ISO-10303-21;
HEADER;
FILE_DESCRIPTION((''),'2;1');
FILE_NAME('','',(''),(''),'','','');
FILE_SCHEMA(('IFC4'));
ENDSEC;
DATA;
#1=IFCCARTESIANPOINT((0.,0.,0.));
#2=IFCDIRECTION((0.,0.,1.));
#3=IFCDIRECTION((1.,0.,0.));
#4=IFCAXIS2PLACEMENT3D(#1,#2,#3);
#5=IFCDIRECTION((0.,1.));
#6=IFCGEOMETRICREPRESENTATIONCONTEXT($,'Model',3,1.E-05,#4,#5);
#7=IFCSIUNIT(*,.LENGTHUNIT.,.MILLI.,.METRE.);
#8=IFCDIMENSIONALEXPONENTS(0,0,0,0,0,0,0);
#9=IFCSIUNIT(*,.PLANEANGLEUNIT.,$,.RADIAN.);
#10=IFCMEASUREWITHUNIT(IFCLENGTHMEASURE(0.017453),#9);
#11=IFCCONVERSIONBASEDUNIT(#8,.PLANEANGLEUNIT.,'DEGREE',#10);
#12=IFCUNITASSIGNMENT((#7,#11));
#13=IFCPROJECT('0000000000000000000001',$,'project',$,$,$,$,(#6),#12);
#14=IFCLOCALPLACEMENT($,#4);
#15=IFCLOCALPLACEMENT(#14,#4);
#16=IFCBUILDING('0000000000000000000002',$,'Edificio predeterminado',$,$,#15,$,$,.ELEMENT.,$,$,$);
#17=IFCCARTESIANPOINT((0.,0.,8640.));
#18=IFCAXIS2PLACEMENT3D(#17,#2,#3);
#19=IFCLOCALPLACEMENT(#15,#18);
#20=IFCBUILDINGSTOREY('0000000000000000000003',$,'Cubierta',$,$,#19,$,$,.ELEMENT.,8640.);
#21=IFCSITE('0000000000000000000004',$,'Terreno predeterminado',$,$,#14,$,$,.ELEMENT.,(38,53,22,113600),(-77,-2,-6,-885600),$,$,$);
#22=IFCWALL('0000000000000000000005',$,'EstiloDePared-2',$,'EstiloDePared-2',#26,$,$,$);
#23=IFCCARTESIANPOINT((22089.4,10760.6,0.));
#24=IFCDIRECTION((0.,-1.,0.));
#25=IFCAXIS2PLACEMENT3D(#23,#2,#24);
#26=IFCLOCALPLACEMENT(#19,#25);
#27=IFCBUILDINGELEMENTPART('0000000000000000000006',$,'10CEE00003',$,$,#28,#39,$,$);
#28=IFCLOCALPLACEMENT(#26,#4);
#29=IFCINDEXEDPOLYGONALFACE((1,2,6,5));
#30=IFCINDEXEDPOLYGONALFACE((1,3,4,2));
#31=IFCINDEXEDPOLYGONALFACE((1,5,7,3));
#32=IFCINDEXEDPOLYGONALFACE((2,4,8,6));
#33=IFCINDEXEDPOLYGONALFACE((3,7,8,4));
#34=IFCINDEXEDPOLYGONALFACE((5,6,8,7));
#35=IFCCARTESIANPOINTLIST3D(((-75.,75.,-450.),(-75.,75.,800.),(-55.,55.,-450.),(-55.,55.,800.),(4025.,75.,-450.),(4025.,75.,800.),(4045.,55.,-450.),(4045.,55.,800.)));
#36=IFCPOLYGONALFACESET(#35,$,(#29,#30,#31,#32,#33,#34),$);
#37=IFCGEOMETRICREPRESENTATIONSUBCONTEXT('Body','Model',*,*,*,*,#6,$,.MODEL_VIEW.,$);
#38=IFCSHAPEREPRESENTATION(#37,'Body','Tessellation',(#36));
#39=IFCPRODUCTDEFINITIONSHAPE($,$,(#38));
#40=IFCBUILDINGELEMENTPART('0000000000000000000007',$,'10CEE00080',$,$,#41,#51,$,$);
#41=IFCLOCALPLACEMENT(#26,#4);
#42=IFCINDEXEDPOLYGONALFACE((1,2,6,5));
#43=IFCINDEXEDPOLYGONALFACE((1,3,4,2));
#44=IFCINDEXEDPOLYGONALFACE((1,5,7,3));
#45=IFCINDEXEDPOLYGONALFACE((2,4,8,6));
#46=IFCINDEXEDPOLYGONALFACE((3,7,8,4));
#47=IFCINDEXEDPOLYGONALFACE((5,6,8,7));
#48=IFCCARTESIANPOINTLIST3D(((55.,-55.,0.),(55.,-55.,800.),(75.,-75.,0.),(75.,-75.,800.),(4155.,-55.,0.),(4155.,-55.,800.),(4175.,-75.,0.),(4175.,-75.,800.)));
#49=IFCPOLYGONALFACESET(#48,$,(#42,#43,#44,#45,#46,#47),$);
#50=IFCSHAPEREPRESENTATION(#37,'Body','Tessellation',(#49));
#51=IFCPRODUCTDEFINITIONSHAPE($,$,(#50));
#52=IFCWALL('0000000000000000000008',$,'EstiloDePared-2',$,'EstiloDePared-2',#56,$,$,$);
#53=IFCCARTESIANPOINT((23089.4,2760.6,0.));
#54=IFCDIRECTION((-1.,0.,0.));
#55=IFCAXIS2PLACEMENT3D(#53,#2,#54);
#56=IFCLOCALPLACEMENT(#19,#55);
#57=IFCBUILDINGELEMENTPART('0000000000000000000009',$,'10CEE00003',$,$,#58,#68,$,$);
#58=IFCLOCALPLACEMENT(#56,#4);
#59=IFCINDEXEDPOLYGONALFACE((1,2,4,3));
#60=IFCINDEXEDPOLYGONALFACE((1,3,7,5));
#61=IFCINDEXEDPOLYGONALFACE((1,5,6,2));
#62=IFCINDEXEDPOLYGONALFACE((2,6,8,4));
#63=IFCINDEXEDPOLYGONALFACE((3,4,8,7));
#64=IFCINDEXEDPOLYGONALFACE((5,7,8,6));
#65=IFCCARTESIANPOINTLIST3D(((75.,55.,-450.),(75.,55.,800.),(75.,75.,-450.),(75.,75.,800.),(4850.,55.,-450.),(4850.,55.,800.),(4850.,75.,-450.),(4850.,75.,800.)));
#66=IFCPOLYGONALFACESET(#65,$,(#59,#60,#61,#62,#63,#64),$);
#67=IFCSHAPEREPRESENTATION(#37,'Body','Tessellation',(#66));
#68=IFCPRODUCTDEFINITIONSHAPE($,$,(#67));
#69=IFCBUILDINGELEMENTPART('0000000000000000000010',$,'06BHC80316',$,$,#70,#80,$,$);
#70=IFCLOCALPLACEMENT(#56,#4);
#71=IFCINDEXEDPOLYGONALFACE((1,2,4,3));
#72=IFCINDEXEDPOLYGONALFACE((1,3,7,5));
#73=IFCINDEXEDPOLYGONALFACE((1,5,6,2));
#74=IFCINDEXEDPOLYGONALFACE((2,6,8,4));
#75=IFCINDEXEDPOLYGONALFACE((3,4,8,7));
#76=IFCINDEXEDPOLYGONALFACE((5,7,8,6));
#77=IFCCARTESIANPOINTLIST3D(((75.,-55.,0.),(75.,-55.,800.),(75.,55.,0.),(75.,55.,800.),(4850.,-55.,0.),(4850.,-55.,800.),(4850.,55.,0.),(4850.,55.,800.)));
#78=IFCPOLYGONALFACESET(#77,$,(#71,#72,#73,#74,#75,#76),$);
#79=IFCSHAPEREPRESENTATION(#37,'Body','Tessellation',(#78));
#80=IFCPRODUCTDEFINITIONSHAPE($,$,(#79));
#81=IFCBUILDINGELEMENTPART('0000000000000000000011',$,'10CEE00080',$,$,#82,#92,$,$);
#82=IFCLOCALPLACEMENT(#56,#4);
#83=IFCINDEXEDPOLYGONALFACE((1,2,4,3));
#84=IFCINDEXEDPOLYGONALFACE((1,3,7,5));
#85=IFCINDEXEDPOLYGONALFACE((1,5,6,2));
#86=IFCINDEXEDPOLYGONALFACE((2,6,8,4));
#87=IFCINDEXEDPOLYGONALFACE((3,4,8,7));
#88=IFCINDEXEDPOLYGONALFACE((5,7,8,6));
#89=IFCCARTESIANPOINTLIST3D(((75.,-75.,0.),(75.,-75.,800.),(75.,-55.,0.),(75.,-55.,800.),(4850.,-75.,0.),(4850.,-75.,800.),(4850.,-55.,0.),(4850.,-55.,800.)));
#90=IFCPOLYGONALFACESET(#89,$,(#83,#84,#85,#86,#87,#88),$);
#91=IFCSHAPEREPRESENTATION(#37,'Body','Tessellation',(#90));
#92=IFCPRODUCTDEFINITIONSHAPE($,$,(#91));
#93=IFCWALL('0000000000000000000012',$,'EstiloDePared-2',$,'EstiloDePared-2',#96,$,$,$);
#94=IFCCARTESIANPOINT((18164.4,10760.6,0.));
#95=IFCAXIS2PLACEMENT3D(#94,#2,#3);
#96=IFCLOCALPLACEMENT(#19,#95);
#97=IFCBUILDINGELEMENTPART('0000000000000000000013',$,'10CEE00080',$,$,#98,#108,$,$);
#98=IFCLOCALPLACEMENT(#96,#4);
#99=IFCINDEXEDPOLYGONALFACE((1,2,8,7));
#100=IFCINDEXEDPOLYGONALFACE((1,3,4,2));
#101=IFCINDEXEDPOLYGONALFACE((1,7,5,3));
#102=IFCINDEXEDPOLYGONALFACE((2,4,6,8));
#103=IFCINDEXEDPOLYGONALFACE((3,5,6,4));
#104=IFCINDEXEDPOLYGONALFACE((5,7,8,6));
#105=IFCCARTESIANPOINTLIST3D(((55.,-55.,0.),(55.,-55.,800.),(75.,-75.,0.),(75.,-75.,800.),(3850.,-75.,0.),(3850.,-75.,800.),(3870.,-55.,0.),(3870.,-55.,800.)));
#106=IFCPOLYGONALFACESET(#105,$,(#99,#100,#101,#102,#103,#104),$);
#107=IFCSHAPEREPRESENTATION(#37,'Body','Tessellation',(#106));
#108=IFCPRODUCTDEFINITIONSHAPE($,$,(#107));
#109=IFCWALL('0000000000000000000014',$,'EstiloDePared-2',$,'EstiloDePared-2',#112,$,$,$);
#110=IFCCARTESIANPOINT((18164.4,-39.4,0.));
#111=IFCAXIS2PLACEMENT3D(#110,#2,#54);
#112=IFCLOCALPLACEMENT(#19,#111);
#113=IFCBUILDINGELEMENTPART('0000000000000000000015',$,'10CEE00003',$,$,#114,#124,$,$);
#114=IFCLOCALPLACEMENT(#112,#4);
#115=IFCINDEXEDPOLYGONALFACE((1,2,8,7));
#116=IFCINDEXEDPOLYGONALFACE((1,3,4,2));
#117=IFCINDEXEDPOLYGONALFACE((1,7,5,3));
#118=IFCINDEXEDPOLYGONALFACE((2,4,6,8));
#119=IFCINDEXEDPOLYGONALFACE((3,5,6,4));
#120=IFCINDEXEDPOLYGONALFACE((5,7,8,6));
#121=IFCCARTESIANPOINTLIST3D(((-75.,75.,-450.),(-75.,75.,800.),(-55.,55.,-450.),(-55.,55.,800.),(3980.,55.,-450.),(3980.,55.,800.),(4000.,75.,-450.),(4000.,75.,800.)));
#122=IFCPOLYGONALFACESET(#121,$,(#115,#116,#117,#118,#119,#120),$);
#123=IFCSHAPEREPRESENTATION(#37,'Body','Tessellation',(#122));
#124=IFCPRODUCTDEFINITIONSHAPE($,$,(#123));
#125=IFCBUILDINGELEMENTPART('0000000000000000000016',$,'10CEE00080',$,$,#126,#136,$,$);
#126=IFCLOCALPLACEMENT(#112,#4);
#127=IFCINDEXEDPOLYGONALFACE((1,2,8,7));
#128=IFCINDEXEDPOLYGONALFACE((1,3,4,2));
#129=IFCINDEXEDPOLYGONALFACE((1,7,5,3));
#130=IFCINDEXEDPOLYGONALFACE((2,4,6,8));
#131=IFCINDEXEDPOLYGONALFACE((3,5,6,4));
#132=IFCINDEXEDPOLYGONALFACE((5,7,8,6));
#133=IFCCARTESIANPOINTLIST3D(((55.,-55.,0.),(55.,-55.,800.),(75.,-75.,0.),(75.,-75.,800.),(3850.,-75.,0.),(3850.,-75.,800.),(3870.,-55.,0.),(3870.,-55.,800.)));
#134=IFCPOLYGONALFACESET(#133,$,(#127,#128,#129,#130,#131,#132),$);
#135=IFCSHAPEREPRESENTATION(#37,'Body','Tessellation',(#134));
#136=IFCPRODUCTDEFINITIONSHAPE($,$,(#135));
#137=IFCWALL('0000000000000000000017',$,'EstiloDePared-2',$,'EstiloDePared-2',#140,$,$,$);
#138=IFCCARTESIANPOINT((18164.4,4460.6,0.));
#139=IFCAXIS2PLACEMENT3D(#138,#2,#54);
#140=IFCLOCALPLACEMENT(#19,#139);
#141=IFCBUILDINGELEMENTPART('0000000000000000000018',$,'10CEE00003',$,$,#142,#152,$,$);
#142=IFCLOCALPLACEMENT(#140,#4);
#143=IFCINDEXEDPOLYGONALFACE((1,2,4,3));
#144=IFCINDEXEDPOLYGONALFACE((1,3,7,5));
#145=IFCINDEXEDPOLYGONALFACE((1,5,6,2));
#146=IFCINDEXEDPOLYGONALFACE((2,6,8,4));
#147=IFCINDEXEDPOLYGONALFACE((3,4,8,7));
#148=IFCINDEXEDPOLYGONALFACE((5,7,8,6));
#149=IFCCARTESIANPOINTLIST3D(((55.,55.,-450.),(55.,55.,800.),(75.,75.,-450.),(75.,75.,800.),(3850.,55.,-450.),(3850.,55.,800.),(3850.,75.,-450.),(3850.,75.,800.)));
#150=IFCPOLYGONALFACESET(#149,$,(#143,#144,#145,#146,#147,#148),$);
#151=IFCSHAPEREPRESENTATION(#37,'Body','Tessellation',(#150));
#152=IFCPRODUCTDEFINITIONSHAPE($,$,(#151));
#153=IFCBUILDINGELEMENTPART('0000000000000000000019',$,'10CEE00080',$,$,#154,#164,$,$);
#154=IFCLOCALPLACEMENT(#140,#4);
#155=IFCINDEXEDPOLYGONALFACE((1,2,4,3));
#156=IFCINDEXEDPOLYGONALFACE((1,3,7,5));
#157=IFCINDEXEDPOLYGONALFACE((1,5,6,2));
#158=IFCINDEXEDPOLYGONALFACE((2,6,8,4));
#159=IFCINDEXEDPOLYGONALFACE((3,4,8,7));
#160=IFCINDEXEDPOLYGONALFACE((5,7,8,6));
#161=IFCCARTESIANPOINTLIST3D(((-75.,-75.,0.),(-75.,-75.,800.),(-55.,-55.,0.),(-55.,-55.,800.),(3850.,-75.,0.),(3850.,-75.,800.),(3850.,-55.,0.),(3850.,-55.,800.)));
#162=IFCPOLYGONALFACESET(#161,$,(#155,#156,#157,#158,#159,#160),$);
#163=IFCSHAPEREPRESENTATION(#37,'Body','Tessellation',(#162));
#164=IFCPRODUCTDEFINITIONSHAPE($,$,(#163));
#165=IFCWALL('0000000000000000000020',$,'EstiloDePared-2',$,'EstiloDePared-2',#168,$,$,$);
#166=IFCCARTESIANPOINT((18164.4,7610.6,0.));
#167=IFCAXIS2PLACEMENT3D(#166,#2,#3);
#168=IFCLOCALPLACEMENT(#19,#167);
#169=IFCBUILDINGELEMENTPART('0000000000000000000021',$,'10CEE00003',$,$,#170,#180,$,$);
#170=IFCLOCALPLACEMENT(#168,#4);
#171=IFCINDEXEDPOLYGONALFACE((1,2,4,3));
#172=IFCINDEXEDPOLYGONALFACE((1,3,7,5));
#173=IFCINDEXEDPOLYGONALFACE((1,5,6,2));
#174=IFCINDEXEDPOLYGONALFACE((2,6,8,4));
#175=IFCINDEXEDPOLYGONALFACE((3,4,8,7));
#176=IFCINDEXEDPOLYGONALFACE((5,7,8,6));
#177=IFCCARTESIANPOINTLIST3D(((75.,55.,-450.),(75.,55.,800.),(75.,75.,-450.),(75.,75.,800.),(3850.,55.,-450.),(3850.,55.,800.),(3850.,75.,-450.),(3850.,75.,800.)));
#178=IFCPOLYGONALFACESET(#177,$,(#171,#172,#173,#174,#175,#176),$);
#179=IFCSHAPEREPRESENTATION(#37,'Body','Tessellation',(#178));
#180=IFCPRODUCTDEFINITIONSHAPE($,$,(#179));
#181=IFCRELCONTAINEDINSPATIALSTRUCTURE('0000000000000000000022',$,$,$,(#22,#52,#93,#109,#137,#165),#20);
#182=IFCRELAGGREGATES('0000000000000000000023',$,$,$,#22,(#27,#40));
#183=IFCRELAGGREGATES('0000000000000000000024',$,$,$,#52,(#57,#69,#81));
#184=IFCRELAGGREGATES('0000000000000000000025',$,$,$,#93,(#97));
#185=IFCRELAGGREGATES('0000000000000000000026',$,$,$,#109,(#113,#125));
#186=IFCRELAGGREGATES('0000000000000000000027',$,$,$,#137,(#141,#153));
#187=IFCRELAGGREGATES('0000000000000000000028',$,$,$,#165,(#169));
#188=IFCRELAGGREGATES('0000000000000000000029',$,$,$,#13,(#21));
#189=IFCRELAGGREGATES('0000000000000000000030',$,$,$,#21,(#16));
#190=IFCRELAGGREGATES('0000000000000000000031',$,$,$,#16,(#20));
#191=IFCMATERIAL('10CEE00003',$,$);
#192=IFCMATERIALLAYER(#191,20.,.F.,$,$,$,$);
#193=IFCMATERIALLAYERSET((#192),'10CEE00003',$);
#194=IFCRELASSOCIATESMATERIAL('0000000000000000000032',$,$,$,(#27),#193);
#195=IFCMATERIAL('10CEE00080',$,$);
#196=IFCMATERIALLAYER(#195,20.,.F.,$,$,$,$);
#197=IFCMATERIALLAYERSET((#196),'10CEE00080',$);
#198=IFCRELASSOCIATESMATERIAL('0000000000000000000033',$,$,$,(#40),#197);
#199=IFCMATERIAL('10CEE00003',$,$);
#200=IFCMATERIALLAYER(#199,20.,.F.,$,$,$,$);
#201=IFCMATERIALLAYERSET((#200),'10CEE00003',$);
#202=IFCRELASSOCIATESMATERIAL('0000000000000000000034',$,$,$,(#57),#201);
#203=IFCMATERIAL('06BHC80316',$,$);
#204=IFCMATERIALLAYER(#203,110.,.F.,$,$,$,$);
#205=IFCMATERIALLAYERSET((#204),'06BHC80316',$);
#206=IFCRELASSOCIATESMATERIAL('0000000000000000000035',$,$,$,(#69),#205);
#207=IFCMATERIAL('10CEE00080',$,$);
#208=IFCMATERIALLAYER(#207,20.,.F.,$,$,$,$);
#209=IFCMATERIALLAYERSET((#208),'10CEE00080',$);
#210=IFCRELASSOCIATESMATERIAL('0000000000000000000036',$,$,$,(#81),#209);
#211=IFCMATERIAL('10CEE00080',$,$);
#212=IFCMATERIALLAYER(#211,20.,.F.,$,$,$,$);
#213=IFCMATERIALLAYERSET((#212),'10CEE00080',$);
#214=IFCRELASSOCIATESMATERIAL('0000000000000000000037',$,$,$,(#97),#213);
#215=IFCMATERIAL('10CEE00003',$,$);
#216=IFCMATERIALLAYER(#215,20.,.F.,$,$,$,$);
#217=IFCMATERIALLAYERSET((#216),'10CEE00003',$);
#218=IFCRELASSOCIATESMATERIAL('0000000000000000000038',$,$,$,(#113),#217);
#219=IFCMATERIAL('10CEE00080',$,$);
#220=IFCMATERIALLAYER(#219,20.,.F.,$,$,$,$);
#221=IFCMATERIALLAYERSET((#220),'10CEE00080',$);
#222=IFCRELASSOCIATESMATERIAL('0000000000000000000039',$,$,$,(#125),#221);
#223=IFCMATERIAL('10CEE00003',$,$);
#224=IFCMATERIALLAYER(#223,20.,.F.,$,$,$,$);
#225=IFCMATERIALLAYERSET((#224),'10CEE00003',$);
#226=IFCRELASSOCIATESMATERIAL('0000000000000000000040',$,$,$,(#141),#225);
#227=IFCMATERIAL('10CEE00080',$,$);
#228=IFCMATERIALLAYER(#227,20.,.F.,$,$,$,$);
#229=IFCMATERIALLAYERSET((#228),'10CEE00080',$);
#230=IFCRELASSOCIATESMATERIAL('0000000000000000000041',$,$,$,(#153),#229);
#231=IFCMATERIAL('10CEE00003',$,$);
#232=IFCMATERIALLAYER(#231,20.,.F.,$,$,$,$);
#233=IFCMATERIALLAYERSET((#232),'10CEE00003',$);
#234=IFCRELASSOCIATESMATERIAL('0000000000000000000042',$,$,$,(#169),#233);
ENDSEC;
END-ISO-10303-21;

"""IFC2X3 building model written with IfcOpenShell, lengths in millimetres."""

from ifc_helpers import new_model, entity, si_unit, converted_unit, direction, frame, origin_with_axes, place, context, subcontext, project, spatial, polyline, outline, extrude, material, layer, layer_set, layer_usage, element, aggregate, save


model = new_model("IFC2X3")

# Units and contexts
model_context = context("Model", 3, precision=1e-05, world=origin_with_axes(), true_north=direction((0.0, 1.0)))
body_context = subcontext(model_context, "Body", "Model", "MODEL_VIEW")
ifc_project = project(units=[si_unit("LENGTHUNIT", "METRE", prefix="MILLI"), converted_unit("PLANEANGLEUNIT", "DEGREE", entity("IfcLengthMeasure", 0.017453), si_unit("PLANEANGLEUNIT", "RADIAN"), dimensions=[0, 0, 0, 0, 0, 0, 0])], contexts=[model_context])

# Site, building, storey
site_placement = place(None, origin_with_axes())
site = spatial("IfcSite", under=ifc_project, at=site_placement, Name="Terreno predeterminado", CompositionType="ELEMENT", RefLatitude=(38, 53, 22, 113600), RefLongitude=(-77, -2, -6, -885600))
building_placement = place(site_placement, origin_with_axes())
building = spatial("IfcBuilding", under=site, at=building_placement, Name="Edificio predeterminado", CompositionType="ELEMENT")
storey_placement = place(building_placement, frame((0.0, 0.0, 8640.0), z_axis=(0.0, 0.0, 1.0), x_axis=(1.0, 0.0, 0.0)))
storey = spatial("IfcBuildingStorey", under=building, at=storey_placement, Name="Cubierta", CompositionType="ELEMENT", Elevation=8640.0)

# Walls, building element parts
wall_1_placement = place(storey_placement, frame((22089.4, 10760.6, 0.0), z_axis=(0.0, 0.0, 1.0), x_axis=(0.0, -1.0, 0.0)))
wall_1 = element("IfcWall", 1, at=wall_1_placement, inside=storey, Name="EstiloDePared-2", ObjectType="EstiloDePared-2")
ifc_material_1 = material(Name="10CEE00003")
ifc_layer_1 = layer(ifc_material_1, 20.0, ventilated=False)
ifc_layer_set_1 = layer_set([ifc_layer_1], Name="10CEE00003")
ifc_layer_usage_1 = layer_usage(ifc_layer_set_1, "AXIS2", "NEGATIVE", -75.0)
building_element_part_1_placement = place(wall_1_placement, origin_with_axes())
building_element_part_1 = element("IfcBuildingElementPart", 2, at=building_element_part_1_placement, material=ifc_layer_usage_1, Name="10CEE00003", context=body_context, shape_type="SweptSolid", body=[
    extrude(outline(polyline([(4025.0, 75.0), (4045.0, 55.0), (-55.0, 55.0), (-75.0, 75.0), (4025.0, 75.0)])), frame((0.0, 0.0, -450.0), z_axis=(0.0, 0.0, 1.0), x_axis=(1.0, 0.0, 0.0)), (0.0, 0.0, 1.0), 1250.0),
])
ifc_material_2 = material(Name="10CEE00080")
ifc_layer_2 = layer(ifc_material_2, 20.0, ventilated=False)
ifc_layer_set_2 = layer_set([ifc_layer_2], Name="10CEE00080")
ifc_layer_usage_2 = layer_usage(ifc_layer_set_2, "AXIS2", "NEGATIVE", 55.0)
building_element_part_2_placement = place(wall_1_placement, origin_with_axes())
building_element_part_2 = element("IfcBuildingElementPart", 3, at=building_element_part_2_placement, material=ifc_layer_usage_2, Name="10CEE00080", context=body_context, shape_type="SweptSolid", body=[
    extrude(outline(polyline([(4155.0, -55.0), (4175.0, -75.0), (75.0, -75.0), (55.0, -55.0), (4155.0, -55.0)])), origin_with_axes(), (0.0, 0.0, 1.0), 800.0),
])
aggregate(wall_1, [building_element_part_1, building_element_part_2])
wall_2_placement = place(storey_placement, frame((23089.4, 2760.6, 0.0), z_axis=(0.0, 0.0, 1.0), x_axis=(-1.0, 0.0, 0.0)))
wall_2 = element("IfcWall", 4, at=wall_2_placement, inside=storey, Name="EstiloDePared-2", ObjectType="EstiloDePared-2")
ifc_material_3 = material(Name="10CEE00003")
ifc_layer_3 = layer(ifc_material_3, 20.0, ventilated=False)
ifc_layer_set_3 = layer_set([ifc_layer_3], Name="10CEE00003")
ifc_layer_usage_3 = layer_usage(ifc_layer_set_3, "AXIS2", "NEGATIVE", -75.0)
building_element_part_3_placement = place(wall_2_placement, origin_with_axes())
building_element_part_3 = element("IfcBuildingElementPart", 5, at=building_element_part_3_placement, material=ifc_layer_usage_3, Name="10CEE00003", context=body_context, shape_type="SweptSolid", body=[
    extrude(outline(polyline([(4850.0, 75.0), (4850.0, 55.0), (75.0, 55.0), (75.0, 75.0), (4850.0, 75.0)])), frame((0.0, 0.0, -450.0), z_axis=(0.0, 0.0, 1.0), x_axis=(1.0, 0.0, 0.0)), (0.0, 0.0, 1.0), 1250.0),
])
ifc_material_4 = material(Name="06BHC80316")
ifc_layer_4 = layer(ifc_material_4, 110.0, ventilated=False)
ifc_layer_set_4 = layer_set([ifc_layer_4], Name="06BHC80316")
ifc_layer_usage_4 = layer_usage(ifc_layer_set_4, "AXIS2", "NEGATIVE", -55.0)
building_element_part_4_placement = place(wall_2_placement, origin_with_axes())
building_element_part_4 = element("IfcBuildingElementPart", 6, at=building_element_part_4_placement, material=ifc_layer_usage_4, Name="06BHC80316", context=body_context, shape_type="SweptSolid", body=[
    extrude(outline(polyline([(4850.0, 55.0), (4850.0, -55.0), (75.0, -55.0), (75.0, 55.0), (4850.0, 55.0)])), origin_with_axes(), (0.0, 0.0, 1.0), 800.0),
])
ifc_material_5 = material(Name="10CEE00080")
ifc_layer_5 = layer(ifc_material_5, 20.0, ventilated=False)
ifc_layer_set_5 = layer_set([ifc_layer_5], Name="10CEE00080")
ifc_layer_usage_5 = layer_usage(ifc_layer_set_5, "AXIS2", "NEGATIVE", 55.0)
building_element_part_5_placement = place(wall_2_placement, origin_with_axes())
building_element_part_5 = element("IfcBuildingElementPart", 7, at=building_element_part_5_placement, material=ifc_layer_usage_5, Name="10CEE00080", context=body_context, shape_type="SweptSolid", body=[
    extrude(outline(polyline([(4850.0, -55.0), (4850.0, -75.0), (75.0, -75.0), (75.0, -55.0), (4850.0, -55.0)])), origin_with_axes(), (0.0, 0.0, 1.0), 800.0),
])
aggregate(wall_2, [building_element_part_3, building_element_part_4, building_element_part_5])

# Wall, building element part
wall_3_placement = place(storey_placement, frame((18164.4, 10760.6, 0.0), z_axis=(0.0, 0.0, 1.0), x_axis=(1.0, 0.0, 0.0)))
wall_3 = element("IfcWall", 8, at=wall_3_placement, inside=storey, Name="EstiloDePared-2", ObjectType="EstiloDePared-2")
ifc_material_6 = material(Name="10CEE00080")
ifc_layer_6 = layer(ifc_material_6, 20.0, ventilated=False)
ifc_layer_set_6 = layer_set([ifc_layer_6], Name="10CEE00080")
ifc_layer_usage_6 = layer_usage(ifc_layer_set_6, "AXIS2", "NEGATIVE", 55.0)
building_element_part_6_placement = place(wall_3_placement, origin_with_axes())
building_element_part_6 = element("IfcBuildingElementPart", 9, at=building_element_part_6_placement, material=ifc_layer_usage_6, Name="10CEE00080", context=body_context, shape_type="SweptSolid", body=[
    extrude(outline(polyline([(3870.0, -55.0), (3850.0, -75.0), (75.0, -75.0), (55.0, -55.0), (3870.0, -55.0)])), origin_with_axes(), (0.0, 0.0, 1.0), 800.0),
])
aggregate(wall_3, [building_element_part_6])

# Walls, building element parts
wall_4_placement = place(storey_placement, frame((18164.4, -39.4, 0.0), z_axis=(0.0, 0.0, 1.0), x_axis=(-1.0, 0.0, 0.0)))
wall_4 = element("IfcWall", 10, at=wall_4_placement, inside=storey, Name="EstiloDePared-2", ObjectType="EstiloDePared-2")
ifc_material_7 = material(Name="10CEE00003")
ifc_layer_7 = layer(ifc_material_7, 20.0, ventilated=False)
ifc_layer_set_7 = layer_set([ifc_layer_7], Name="10CEE00003")
ifc_layer_usage_7 = layer_usage(ifc_layer_set_7, "AXIS2", "NEGATIVE", -75.0)
building_element_part_7_placement = place(wall_4_placement, origin_with_axes())
building_element_part_7 = element("IfcBuildingElementPart", 11, at=building_element_part_7_placement, material=ifc_layer_usage_7, Name="10CEE00003", context=body_context, shape_type="SweptSolid", body=[
    extrude(outline(polyline([(4000.0, 75.0), (3980.0, 55.0), (-55.0, 55.0), (-75.0, 75.0), (4000.0, 75.0)])), frame((0.0, 0.0, -450.0), z_axis=(0.0, 0.0, 1.0), x_axis=(1.0, 0.0, 0.0)), (0.0, 0.0, 1.0), 1250.0),
])
ifc_material_8 = material(Name="10CEE00080")
ifc_layer_8 = layer(ifc_material_8, 20.0, ventilated=False)
ifc_layer_set_8 = layer_set([ifc_layer_8], Name="10CEE00080")
ifc_layer_usage_8 = layer_usage(ifc_layer_set_8, "AXIS2", "NEGATIVE", 55.0)
building_element_part_8_placement = place(wall_4_placement, origin_with_axes())
building_element_part_8 = element("IfcBuildingElementPart", 12, at=building_element_part_8_placement, material=ifc_layer_usage_8, Name="10CEE00080", context=body_context, shape_type="SweptSolid", body=[
    extrude(outline(polyline([(3870.0, -55.0), (3850.0, -75.0), (75.0, -75.0), (55.0, -55.0), (3870.0, -55.0)])), origin_with_axes(), (0.0, 0.0, 1.0), 800.0),
])
aggregate(wall_4, [building_element_part_7, building_element_part_8])
wall_5_placement = place(storey_placement, frame((18164.4, 4460.6, 0.0), z_axis=(0.0, 0.0, 1.0), x_axis=(-1.0, 0.0, 0.0)))
wall_5 = element("IfcWall", 13, at=wall_5_placement, inside=storey, Name="EstiloDePared-2", ObjectType="EstiloDePared-2")
ifc_material_9 = material(Name="10CEE00003")
ifc_layer_9 = layer(ifc_material_9, 20.0, ventilated=False)
ifc_layer_set_9 = layer_set([ifc_layer_9], Name="10CEE00003")
ifc_layer_usage_9 = layer_usage(ifc_layer_set_9, "AXIS2", "NEGATIVE", -75.0)
building_element_part_9_placement = place(wall_5_placement, origin_with_axes())
building_element_part_9 = element("IfcBuildingElementPart", 14, at=building_element_part_9_placement, material=ifc_layer_usage_9, Name="10CEE00003", context=body_context, shape_type="SweptSolid", body=[
    extrude(outline(polyline([(3850.0, 75.0), (3850.0, 55.0), (55.0, 55.0), (75.0, 75.0), (3850.0, 75.0)])), frame((0.0, 0.0, -450.0), z_axis=(0.0, 0.0, 1.0), x_axis=(1.0, 0.0, 0.0)), (0.0, 0.0, 1.0), 1250.0),
])
ifc_material_10 = material(Name="10CEE00080")
ifc_layer_10 = layer(ifc_material_10, 20.0, ventilated=False)
ifc_layer_set_10 = layer_set([ifc_layer_10], Name="10CEE00080")
ifc_layer_usage_10 = layer_usage(ifc_layer_set_10, "AXIS2", "NEGATIVE", 55.0)
building_element_part_10_placement = place(wall_5_placement, origin_with_axes())
building_element_part_10 = element("IfcBuildingElementPart", 15, at=building_element_part_10_placement, material=ifc_layer_usage_10, Name="10CEE00080", context=body_context, shape_type="SweptSolid", body=[
    extrude(outline(polyline([(3850.0, -55.0), (3850.0, -75.0), (-75.0, -75.0), (-55.0, -55.0), (3850.0, -55.0)])), origin_with_axes(), (0.0, 0.0, 1.0), 800.0),
])
aggregate(wall_5, [building_element_part_9, building_element_part_10])
wall_6_placement = place(storey_placement, frame((18164.4, 7610.6, 0.0), z_axis=(0.0, 0.0, 1.0), x_axis=(1.0, 0.0, 0.0)))
wall_6 = element("IfcWall", 16, at=wall_6_placement, inside=storey, Name="EstiloDePared-2", ObjectType="EstiloDePared-2")
ifc_material_11 = material(Name="10CEE00003")
ifc_layer_11 = layer(ifc_material_11, 20.0, ventilated=False)
ifc_layer_set_11 = layer_set([ifc_layer_11], Name="10CEE00003")
ifc_layer_usage_11 = layer_usage(ifc_layer_set_11, "AXIS2", "NEGATIVE", -75.0)
building_element_part_11_placement = place(wall_6_placement, origin_with_axes())
building_element_part_11 = element("IfcBuildingElementPart", 17, at=building_element_part_11_placement, material=ifc_layer_usage_11, Name="10CEE00003", context=body_context, shape_type="SweptSolid", body=[
    extrude(outline(polyline([(3850.0, 75.0), (3850.0, 55.0), (75.0, 55.0), (75.0, 75.0), (3850.0, 75.0)])), frame((0.0, 0.0, -450.0), z_axis=(0.0, 0.0, 1.0), x_axis=(1.0, 0.0, 0.0)), (0.0, 0.0, 1.0), 1250.0),
])
aggregate(wall_6, [building_element_part_11])

save(model, "model.ifc")
